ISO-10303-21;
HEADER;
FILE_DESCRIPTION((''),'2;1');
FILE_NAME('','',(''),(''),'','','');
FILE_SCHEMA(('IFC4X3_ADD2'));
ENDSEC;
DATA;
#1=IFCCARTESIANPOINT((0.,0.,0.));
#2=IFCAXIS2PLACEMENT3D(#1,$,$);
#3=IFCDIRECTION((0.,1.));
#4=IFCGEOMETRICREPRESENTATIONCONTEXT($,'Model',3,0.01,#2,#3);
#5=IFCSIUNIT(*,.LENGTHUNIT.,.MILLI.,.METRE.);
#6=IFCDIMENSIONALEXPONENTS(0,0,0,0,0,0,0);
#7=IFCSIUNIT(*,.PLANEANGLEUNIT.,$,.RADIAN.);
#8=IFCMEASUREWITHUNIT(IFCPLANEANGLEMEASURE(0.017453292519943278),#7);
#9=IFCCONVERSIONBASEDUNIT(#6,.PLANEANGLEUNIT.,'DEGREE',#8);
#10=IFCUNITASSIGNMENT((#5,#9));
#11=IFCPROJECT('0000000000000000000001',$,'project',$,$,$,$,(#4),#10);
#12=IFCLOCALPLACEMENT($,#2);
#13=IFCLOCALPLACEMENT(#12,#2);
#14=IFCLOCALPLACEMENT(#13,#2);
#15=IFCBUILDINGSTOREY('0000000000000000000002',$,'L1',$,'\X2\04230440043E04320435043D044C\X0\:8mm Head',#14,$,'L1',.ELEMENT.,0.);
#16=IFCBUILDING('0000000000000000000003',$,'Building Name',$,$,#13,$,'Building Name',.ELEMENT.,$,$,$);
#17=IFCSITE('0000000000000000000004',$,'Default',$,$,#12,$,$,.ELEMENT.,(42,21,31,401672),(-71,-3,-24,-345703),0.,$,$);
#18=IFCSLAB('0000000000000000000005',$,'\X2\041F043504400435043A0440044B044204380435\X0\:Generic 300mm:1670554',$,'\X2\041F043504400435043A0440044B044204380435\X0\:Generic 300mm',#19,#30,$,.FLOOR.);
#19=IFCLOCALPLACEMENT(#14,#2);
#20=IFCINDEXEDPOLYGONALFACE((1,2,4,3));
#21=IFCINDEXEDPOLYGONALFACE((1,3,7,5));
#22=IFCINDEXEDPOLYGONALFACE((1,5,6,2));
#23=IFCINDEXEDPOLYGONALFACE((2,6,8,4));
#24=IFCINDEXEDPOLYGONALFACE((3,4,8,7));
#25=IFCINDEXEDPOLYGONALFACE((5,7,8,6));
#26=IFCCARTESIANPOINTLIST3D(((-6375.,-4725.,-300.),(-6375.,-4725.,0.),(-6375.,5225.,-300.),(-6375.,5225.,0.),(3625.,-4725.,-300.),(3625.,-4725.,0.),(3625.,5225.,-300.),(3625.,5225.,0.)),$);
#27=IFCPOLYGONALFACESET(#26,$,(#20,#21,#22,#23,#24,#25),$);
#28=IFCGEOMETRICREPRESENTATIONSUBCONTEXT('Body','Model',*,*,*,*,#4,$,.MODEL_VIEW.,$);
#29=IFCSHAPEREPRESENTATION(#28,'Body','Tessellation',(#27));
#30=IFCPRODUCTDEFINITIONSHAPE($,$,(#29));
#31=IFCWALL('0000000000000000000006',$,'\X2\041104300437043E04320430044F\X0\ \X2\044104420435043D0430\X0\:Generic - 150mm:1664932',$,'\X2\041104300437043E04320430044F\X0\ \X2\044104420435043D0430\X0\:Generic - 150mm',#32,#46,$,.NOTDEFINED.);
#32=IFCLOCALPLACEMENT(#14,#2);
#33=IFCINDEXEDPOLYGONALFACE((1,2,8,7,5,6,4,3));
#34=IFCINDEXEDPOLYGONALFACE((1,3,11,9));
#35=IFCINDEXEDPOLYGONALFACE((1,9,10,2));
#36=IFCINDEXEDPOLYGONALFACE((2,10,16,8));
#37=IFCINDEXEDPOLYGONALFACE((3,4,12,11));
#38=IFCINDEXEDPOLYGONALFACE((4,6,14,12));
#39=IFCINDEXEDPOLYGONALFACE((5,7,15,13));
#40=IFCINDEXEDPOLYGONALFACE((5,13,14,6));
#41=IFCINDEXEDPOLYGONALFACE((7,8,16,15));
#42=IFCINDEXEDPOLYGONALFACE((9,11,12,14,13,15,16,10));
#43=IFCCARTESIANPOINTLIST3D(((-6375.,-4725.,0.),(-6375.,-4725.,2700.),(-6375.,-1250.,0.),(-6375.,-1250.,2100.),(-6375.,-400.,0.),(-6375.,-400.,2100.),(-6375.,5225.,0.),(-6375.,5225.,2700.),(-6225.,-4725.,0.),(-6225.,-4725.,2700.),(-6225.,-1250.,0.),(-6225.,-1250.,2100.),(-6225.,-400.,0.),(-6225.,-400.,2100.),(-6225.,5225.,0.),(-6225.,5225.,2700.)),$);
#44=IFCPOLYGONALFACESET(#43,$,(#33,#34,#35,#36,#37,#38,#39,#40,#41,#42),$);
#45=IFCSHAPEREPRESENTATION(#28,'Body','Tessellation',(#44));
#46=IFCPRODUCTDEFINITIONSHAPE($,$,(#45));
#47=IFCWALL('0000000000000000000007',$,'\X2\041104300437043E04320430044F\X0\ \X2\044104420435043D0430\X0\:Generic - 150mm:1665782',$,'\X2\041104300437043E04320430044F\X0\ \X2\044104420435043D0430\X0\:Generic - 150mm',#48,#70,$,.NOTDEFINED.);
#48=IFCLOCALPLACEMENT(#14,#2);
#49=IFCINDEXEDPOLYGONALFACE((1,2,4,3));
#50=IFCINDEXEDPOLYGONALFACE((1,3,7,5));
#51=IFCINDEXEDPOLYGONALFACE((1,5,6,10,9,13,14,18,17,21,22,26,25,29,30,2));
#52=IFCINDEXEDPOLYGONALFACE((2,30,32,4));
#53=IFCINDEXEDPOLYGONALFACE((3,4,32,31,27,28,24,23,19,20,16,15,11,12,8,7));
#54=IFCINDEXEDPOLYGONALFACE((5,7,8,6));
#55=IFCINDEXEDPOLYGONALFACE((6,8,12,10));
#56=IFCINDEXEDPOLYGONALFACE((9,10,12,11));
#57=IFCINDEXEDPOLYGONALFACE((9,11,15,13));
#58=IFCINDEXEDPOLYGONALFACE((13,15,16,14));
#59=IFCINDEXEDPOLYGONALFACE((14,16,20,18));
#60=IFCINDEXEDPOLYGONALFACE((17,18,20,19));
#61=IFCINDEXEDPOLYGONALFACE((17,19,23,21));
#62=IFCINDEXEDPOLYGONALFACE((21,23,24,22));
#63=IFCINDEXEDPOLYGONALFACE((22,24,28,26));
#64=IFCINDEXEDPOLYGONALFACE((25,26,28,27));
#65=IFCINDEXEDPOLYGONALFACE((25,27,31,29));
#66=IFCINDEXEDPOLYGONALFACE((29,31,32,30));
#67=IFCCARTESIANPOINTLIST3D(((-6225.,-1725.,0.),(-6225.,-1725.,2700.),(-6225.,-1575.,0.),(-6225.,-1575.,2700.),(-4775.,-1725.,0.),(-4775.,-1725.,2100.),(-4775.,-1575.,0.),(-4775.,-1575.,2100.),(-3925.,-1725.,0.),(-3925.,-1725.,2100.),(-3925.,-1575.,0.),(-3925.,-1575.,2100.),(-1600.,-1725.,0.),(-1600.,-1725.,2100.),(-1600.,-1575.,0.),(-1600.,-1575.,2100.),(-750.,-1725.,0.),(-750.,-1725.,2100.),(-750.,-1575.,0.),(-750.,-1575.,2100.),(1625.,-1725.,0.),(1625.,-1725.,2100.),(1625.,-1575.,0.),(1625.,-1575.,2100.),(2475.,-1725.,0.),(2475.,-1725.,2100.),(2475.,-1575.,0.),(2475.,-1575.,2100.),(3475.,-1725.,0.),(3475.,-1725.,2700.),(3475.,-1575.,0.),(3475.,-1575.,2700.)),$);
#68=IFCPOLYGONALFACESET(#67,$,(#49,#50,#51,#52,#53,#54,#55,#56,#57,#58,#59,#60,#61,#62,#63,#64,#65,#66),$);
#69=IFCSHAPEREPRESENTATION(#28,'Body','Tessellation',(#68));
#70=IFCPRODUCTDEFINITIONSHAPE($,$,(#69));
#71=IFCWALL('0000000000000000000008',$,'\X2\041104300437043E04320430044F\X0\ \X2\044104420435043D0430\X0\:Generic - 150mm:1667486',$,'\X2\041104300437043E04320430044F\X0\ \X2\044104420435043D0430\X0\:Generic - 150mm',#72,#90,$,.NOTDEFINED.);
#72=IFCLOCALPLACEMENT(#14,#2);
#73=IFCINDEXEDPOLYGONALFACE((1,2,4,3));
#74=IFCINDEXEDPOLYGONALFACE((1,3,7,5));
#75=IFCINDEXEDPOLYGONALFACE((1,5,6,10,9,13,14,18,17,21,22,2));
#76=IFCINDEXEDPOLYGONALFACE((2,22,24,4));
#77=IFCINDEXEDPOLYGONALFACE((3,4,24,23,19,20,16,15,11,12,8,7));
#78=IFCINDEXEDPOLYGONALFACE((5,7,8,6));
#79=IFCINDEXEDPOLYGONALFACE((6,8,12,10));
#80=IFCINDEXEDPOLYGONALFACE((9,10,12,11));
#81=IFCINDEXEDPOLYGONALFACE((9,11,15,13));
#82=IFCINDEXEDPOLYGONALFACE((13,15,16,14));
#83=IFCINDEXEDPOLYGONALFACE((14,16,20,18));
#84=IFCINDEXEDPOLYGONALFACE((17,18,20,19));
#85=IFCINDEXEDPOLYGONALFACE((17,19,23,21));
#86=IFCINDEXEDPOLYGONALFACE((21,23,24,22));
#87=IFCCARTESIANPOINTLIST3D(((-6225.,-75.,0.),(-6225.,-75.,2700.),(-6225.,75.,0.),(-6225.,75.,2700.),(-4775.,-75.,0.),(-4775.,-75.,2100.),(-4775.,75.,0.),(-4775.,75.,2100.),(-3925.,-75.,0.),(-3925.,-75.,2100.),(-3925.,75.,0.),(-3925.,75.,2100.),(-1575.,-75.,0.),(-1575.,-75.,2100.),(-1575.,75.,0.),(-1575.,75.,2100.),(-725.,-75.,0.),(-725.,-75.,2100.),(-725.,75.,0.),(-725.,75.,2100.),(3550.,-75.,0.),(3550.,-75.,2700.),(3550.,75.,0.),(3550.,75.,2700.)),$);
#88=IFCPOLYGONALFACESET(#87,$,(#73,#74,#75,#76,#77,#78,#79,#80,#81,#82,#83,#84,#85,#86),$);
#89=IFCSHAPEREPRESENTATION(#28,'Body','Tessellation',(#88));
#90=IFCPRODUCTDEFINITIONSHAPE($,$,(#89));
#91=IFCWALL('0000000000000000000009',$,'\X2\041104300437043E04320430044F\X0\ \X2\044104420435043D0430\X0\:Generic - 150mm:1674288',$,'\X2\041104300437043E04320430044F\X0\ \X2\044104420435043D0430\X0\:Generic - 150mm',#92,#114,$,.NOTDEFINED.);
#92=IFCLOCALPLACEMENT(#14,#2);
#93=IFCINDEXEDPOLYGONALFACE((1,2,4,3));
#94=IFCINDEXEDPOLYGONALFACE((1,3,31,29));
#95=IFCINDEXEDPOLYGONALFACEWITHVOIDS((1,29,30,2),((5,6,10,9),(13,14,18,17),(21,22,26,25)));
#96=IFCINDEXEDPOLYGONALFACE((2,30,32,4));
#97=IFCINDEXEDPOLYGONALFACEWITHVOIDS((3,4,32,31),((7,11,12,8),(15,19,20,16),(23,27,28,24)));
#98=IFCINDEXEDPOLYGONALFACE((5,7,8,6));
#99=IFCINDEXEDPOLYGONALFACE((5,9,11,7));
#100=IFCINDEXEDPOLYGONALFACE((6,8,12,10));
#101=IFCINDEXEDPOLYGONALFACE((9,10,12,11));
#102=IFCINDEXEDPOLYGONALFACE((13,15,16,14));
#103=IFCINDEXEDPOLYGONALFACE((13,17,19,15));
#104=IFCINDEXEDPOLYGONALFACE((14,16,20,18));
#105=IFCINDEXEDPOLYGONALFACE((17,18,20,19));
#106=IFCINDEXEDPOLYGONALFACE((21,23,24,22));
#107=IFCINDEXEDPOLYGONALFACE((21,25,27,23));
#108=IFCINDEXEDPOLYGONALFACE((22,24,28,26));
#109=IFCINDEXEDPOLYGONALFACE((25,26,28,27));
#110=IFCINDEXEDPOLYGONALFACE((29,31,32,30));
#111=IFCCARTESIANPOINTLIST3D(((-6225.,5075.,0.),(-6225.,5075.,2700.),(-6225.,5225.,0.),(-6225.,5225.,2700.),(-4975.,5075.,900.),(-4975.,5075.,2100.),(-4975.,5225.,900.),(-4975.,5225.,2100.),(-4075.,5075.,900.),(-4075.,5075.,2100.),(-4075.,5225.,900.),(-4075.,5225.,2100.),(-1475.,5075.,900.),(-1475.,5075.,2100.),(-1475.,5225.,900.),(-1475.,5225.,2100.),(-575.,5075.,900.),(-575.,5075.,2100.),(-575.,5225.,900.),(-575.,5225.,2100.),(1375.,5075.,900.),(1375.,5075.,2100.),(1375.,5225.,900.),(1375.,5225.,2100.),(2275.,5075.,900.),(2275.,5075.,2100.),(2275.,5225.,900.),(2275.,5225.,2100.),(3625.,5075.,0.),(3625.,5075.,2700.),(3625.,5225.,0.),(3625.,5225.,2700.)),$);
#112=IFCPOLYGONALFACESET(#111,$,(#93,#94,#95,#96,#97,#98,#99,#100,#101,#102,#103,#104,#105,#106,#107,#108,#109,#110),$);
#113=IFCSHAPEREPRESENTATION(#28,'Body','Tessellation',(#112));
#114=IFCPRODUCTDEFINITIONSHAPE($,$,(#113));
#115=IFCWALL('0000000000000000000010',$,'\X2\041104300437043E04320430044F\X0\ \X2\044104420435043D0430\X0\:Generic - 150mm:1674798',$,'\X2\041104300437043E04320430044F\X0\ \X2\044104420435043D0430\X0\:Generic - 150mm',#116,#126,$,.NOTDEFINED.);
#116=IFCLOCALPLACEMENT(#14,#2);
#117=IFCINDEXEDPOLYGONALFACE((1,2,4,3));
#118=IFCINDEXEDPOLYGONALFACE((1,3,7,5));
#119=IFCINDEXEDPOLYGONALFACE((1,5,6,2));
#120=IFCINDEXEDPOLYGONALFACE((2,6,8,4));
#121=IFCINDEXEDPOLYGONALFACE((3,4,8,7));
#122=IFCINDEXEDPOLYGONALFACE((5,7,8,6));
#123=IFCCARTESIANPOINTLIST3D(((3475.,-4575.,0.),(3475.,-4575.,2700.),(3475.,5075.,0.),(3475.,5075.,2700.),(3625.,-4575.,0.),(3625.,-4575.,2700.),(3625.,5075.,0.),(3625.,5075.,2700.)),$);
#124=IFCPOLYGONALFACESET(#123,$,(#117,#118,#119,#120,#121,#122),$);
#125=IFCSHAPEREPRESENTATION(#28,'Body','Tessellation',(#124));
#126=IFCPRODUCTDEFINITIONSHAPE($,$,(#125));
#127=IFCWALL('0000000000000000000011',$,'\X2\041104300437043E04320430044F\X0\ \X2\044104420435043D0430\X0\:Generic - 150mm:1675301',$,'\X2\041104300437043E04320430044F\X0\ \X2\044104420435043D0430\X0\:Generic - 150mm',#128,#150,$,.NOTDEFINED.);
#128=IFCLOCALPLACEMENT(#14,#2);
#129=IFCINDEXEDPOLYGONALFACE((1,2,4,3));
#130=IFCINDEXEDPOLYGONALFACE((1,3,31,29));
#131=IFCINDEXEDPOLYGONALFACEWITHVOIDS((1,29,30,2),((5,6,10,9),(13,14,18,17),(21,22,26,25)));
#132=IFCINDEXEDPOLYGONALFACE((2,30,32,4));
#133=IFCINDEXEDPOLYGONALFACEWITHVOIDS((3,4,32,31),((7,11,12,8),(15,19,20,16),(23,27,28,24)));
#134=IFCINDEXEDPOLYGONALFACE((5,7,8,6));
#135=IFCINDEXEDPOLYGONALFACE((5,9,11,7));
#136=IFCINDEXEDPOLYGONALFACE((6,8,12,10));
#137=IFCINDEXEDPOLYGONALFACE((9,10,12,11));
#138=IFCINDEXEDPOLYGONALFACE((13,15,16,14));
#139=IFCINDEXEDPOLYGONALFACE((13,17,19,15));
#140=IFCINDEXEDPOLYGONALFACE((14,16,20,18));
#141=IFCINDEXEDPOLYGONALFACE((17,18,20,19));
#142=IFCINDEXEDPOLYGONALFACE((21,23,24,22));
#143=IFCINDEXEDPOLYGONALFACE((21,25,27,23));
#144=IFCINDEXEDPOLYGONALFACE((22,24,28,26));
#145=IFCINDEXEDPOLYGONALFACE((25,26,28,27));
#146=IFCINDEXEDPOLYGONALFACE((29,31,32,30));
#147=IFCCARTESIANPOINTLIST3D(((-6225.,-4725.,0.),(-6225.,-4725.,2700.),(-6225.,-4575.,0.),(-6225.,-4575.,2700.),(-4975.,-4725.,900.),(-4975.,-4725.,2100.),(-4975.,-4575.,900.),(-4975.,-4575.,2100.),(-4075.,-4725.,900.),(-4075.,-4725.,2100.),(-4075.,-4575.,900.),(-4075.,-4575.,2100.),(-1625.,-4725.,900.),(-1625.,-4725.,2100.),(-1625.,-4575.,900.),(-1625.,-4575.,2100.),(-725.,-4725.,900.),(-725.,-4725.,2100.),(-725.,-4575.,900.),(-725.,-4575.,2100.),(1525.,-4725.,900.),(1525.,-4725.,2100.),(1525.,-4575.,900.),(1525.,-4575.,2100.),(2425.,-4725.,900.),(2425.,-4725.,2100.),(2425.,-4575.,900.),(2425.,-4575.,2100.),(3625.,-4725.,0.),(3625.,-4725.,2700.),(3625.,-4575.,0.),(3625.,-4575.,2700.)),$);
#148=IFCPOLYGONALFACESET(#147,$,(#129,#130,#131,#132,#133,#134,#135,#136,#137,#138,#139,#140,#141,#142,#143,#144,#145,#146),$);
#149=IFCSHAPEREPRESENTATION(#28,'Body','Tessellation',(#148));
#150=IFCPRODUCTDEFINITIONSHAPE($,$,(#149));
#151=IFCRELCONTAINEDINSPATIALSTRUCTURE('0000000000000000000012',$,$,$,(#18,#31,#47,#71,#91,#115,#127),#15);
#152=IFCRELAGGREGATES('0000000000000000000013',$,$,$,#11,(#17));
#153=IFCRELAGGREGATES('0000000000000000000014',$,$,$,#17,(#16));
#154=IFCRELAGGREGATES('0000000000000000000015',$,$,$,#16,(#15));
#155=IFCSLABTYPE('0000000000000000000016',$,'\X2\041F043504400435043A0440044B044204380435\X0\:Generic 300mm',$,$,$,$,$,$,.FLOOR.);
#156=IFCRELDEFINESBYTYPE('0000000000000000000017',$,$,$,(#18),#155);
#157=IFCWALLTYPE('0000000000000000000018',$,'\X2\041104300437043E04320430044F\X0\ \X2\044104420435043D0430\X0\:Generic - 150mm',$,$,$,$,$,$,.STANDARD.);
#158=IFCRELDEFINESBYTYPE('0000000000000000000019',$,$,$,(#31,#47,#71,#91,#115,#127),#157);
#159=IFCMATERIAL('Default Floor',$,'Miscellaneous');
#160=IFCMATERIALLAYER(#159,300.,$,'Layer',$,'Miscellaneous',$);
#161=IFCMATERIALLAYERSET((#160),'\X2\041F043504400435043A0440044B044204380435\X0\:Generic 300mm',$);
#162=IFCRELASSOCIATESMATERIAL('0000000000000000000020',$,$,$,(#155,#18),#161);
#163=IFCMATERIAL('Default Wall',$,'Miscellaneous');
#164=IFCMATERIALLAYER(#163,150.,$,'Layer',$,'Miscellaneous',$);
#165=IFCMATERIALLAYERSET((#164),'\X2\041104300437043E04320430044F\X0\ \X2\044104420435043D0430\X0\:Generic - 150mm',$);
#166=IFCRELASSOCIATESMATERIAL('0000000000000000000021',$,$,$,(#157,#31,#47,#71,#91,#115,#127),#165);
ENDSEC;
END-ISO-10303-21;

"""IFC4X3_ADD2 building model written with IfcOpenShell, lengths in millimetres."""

from ifc_helpers import new_model, entity, si_unit, converted_unit, direction, frame, frame_2d, origin, origin_2d_with_axis, place, context, subcontext, project, spatial, rectangle, extrude, material, layer, layer_set, layer_usage, type_object, element, save


model = new_model("IFC4X3_ADD2")

# Units and contexts
model_context = context("Model", 3, precision=0.01, world=origin(), true_north=direction((0.0, 1.0)))
body_context = subcontext(model_context, "Body", "Model", "MODEL_VIEW")
ifc_project = project(units=[si_unit("LENGTHUNIT", "METRE", prefix="MILLI"), converted_unit("PLANEANGLEUNIT", "DEGREE", entity("IfcPlaneAngleMeasure", 0.017453292519943278), si_unit("PLANEANGLEUNIT", "RADIAN"), dimensions=[0, 0, 0, 0, 0, 0, 0])], contexts=[model_context])

# Site, building, storey
site_placement = place(None, origin())
site = spatial("IfcSite", under=ifc_project, at=site_placement, Name="Default", CompositionType="ELEMENT", RefLatitude=(42, 21, 31, 401672), RefLongitude=(-71, -3, -24, -345703), RefElevation=0.0)
building_placement = place(site_placement, origin())
building = spatial("IfcBuilding", under=site, at=building_placement, Name="Building Name", LongName="Building Name", CompositionType="ELEMENT")
storey_placement = place(building_placement, origin())
storey = spatial("IfcBuildingStorey", under=building, at=storey_placement, Name="L1", ObjectType="Уровень:8mm Head", LongName="L1", CompositionType="ELEMENT", Elevation=0.0)

# Slab
ifc_material_1 = material(Name="Default Floor", Category="Miscellaneous")
ifc_layer_1 = layer(ifc_material_1, 300.0, Name="Layer", Category="Miscellaneous")
ifc_layer_set_1 = layer_set([ifc_layer_1], Name="Перекрытие:Generic 300mm")
ifc_layer_usage = layer_usage(ifc_layer_set_1, "AXIS3", "POSITIVE", 0.0)
slab_type = type_object("IfcSlabType", Name="Перекрытие:Generic 300mm", PredefinedType="FLOOR", material=ifc_layer_set_1)
slab_placement = place(storey_placement, origin())
element("IfcSlab", 1, at=slab_placement, inside=storey, type_object=slab_type, material=ifc_layer_usage, Name="Перекрытие:Generic 300mm:1670554", ObjectType="Перекрытие:Generic 300mm", PredefinedType="FLOOR", context=body_context, shape_type="SweptSolid", body=[
    extrude(rectangle(XDim=9950.0, YDim=10000.0, at=origin_2d_with_axis()), frame((-1375.0, 250.0, 0.0), z_axis=(0.0, 0.0, -1.0), x_axis=(0.0, 1.0, 0.0)), (0.0, 0.0, 1.0), 300.0),
])

# Wall, opening
ifc_material_2 = material(Name="Default Wall", Category="Miscellaneous")
ifc_layer_2 = layer(ifc_material_2, 150.0, Name="Layer", Category="Miscellaneous")
ifc_layer_set_2 = layer_set([ifc_layer_2], Name="Базовая стена:Generic - 150mm")
wall_type = type_object("IfcWallType", Name="Базовая стена:Generic - 150mm", PredefinedType="STANDARD", material=ifc_layer_set_2)
wall_1_placement = place(storey_placement, frame((-6300.0, 5225.0, 0.0), z_axis=(0.0, 0.0, 1.0), x_axis=(0.0, -1.0, 0.0)))
wall_1 = element("IfcWall", 2, at=wall_1_placement, inside=storey, type_object=wall_type, material=ifc_layer_set_2, Name="Базовая стена:Generic - 150mm:1664932", ObjectType="Базовая стена:Generic - 150mm", PredefinedType="NOTDEFINED", context=body_context, shape_type="SweptSolid", body=[
    extrude(rectangle(XDim=9950.0, YDim=150.0, at=frame_2d((4975.0, 0.0), x_axis=(-1.0, 0.0))), origin(), (0.0, 0.0, 1.0), 2700.0),
])
opening_1_placement = place(wall_1_placement, frame((6475.0, 75.0, 0.0)))
element("IfcOpeningElement", 3, at=opening_1_placement, cuts=wall_1, PredefinedType="OPENING", context=body_context, shape_type="SweptSolid", body=[
    extrude(rectangle(XDim=2100.0, YDim=850.0, at=frame_2d((1050.0, 425.0), x_axis=(1.0, 0.0))), frame((0.0, 0.0, 0.0), z_axis=(0.0, -1.0, 0.0), x_axis=(0.0, 0.0, 1.0)), (0.0, 0.0, 1.0), 150.0),
])

# Walls, openings
wall_2_placement = place(storey_placement, frame((3475.0, -1650.0, 0.0), z_axis=(0.0, 0.0, 1.0), x_axis=(-1.0, 0.0, 0.0)))
wall_2 = element("IfcWall", 4, at=wall_2_placement, inside=storey, type_object=wall_type, material=ifc_layer_set_2, Name="Базовая стена:Generic - 150mm:1665782", ObjectType="Базовая стена:Generic - 150mm", PredefinedType="NOTDEFINED", context=body_context, shape_type="SweptSolid", body=[
    extrude(rectangle(XDim=9700.0, YDim=150.0, at=frame_2d((4850.0, 0.0), x_axis=(1.0, 0.0))), origin(), (0.0, 0.0, 1.0), 2700.0),
])
opening_2_placement = place(wall_2_placement, frame((7400.0, -75.0, 0.0)))
element("IfcOpeningElement", 5, at=opening_2_placement, cuts=wall_2, PredefinedType="OPENING", context=body_context, shape_type="SweptSolid", body=[
    extrude(rectangle(XDim=2100.0, YDim=850.0, at=frame_2d((1050.0, 425.0), x_axis=(1.0, 0.0))), frame((0.0, 0.0, 0.0), z_axis=(0.0, 1.0, 0.0), x_axis=(0.0, 0.0, 1.0)), (0.0, 0.0, 1.0), 150.0),
])
opening_3_placement = place(wall_2_placement, frame((4225.0, -75.0, 0.0)))
element("IfcOpeningElement", 6, at=opening_3_placement, cuts=wall_2, PredefinedType="OPENING", context=body_context, shape_type="SweptSolid", body=[
    extrude(rectangle(XDim=2100.0, YDim=850.0, at=frame_2d((1050.0, 425.0), x_axis=(1.0, 0.0))), frame((0.0, 0.0, 0.0), z_axis=(0.0, 1.0, 0.0), x_axis=(0.0, 0.0, 1.0)), (0.0, 0.0, 1.0), 150.0),
])
opening_4_placement = place(wall_2_placement, frame((1000.0, -75.0, 0.0)))
element("IfcOpeningElement", 7, at=opening_4_placement, cuts=wall_2, PredefinedType="OPENING", context=body_context, shape_type="SweptSolid", body=[
    extrude(rectangle(XDim=2100.0, YDim=850.0, at=frame_2d((1050.0, 425.0), x_axis=(1.0, 0.0))), frame((0.0, 0.0, 0.0), z_axis=(0.0, 1.0, 0.0), x_axis=(0.0, 0.0, 1.0)), (0.0, 0.0, 1.0), 150.0),
])
wall_3_placement = place(storey_placement, frame((3550.0, 0.0, 0.0), z_axis=(0.0, 0.0, 1.0), x_axis=(-1.0, 0.0, 0.0)))
wall_3 = element("IfcWall", 8, at=wall_3_placement, inside=storey, type_object=wall_type, material=ifc_layer_set_2, Name="Базовая стена:Generic - 150mm:1667486", ObjectType="Базовая стена:Generic - 150mm", PredefinedType="NOTDEFINED", context=body_context, shape_type="SweptSolid", body=[
    extrude(rectangle(XDim=9775.0, YDim=150.0, at=frame_2d((4887.5, 0.0), x_axis=(1.0, 0.0))), origin(), (0.0, 0.0, 1.0), 2700.0),
])
opening_5_placement = place(wall_3_placement, frame((8325.0, 75.0, 0.0)))
element("IfcOpeningElement", 9, at=opening_5_placement, cuts=wall_3, PredefinedType="OPENING", context=body_context, shape_type="SweptSolid", body=[
    extrude(rectangle(XDim=2100.0, YDim=850.0, at=frame_2d((1050.0, 425.0), x_axis=(1.0, 0.0))), frame((0.0, 0.0, 0.0), z_axis=(0.0, -1.0, 0.0), x_axis=(0.0, 0.0, 1.0)), (0.0, 0.0, 1.0), 150.0),
])
opening_6_placement = place(wall_3_placement, frame((5125.0, 75.0, 0.0)))
element("IfcOpeningElement", 10, at=opening_6_placement, cuts=wall_3, PredefinedType="OPENING", context=body_context, shape_type="SweptSolid", body=[
    extrude(rectangle(XDim=2100.0, YDim=850.0, at=frame_2d((1050.0, 425.0), x_axis=(1.0, 0.0))), frame((0.0, 0.0, 0.0), z_axis=(0.0, -1.0, 0.0), x_axis=(0.0, 0.0, 1.0)), (0.0, 0.0, 1.0), 150.0),
])
wall_4_placement = place(storey_placement, frame((-6225.0, 5150.0, 0.0)))
wall_4 = element("IfcWall", 11, at=wall_4_placement, inside=storey, type_object=wall_type, material=ifc_layer_set_2, Name="Базовая стена:Generic - 150mm:1674288", ObjectType="Базовая стена:Generic - 150mm", PredefinedType="NOTDEFINED", context=body_context, shape_type="SweptSolid", body=[
    extrude(rectangle(XDim=9850.0, YDim=150.0, at=frame_2d((4925.0, 0.0), x_axis=(-1.0, 0.0))), origin(), (0.0, 0.0, 1.0), 2700.0),
])
opening_7_placement = place(wall_4_placement, frame((1250.0, -75.0, 900.0)))
element("IfcOpeningElement", 12, at=opening_7_placement, cuts=wall_4, PredefinedType="OPENING", context=body_context, shape_type="SweptSolid", body=[
    extrude(rectangle(XDim=1200.0, YDim=900.0, at=frame_2d((600.0, 450.0), x_axis=(-1.0, 0.0))), frame((0.0, 0.0, 0.0), z_axis=(0.0, 1.0, 0.0), x_axis=(0.0, 0.0, 1.0)), (0.0, 0.0, 1.0), 150.0),
])
opening_8_placement = place(wall_4_placement, frame((4750.0, -75.0, 900.0)))
element("IfcOpeningElement", 13, at=opening_8_placement, cuts=wall_4, PredefinedType="OPENING", context=body_context, shape_type="SweptSolid", body=[
    extrude(rectangle(XDim=1200.0, YDim=900.0, at=frame_2d((600.0, 450.0), x_axis=(-1.0, 0.0))), frame((0.0, 0.0, 0.0), z_axis=(0.0, 1.0, 0.0), x_axis=(0.0, 0.0, 1.0)), (0.0, 0.0, 1.0), 150.0),
])
opening_9_placement = place(wall_4_placement, frame((7600.0, -75.0, 900.0)))
element("IfcOpeningElement", 14, at=opening_9_placement, cuts=wall_4, PredefinedType="OPENING", context=body_context, shape_type="SweptSolid", body=[
    extrude(rectangle(XDim=1200.0, YDim=900.0, at=frame_2d((600.0, 450.0), x_axis=(-1.0, 0.0))), frame((0.0, 0.0, 0.0), z_axis=(0.0, 1.0, 0.0), x_axis=(0.0, 0.0, 1.0)), (0.0, 0.0, 1.0), 150.0),
])

# Wall
wall_5_placement = place(storey_placement, frame((3550.0, -4575.0, 0.0), z_axis=(0.0, 0.0, 1.0), x_axis=(0.0, 1.0, 0.0)))
element("IfcWall", 15, at=wall_5_placement, inside=storey, type_object=wall_type, material=ifc_layer_set_2, Name="Базовая стена:Generic - 150mm:1674798", ObjectType="Базовая стена:Generic - 150mm", PredefinedType="NOTDEFINED", context=body_context, shape_type="SweptSolid", body=[
    extrude(rectangle(XDim=9650.0, YDim=150.0, at=frame_2d((4825.0, 0.0), x_axis=(-1.0, 0.0))), origin(), (0.0, 0.0, 1.0), 2700.0),
])

# Wall, openings
wall_6_placement = place(storey_placement, frame((-6225.0, -4650.0, 0.0)))
wall_6 = element("IfcWall", 16, at=wall_6_placement, inside=storey, type_object=wall_type, material=ifc_layer_set_2, Name="Базовая стена:Generic - 150mm:1675301", ObjectType="Базовая стена:Generic - 150mm", PredefinedType="NOTDEFINED", context=body_context, shape_type="SweptSolid", body=[
    extrude(rectangle(XDim=9850.0, YDim=150.0, at=frame_2d((4925.0, 0.0), x_axis=(-1.0, 0.0))), origin(), (0.0, 0.0, 1.0), 2700.0),
])
opening_10_placement = place(wall_6_placement, frame((8650.0, 75.0, 900.0)))
element("IfcOpeningElement", 17, at=opening_10_placement, cuts=wall_6, PredefinedType="OPENING", context=body_context, shape_type="SweptSolid", body=[
    extrude(rectangle(XDim=1200.0, YDim=900.0, at=frame_2d((600.0, 450.0), x_axis=(-1.0, 0.0))), frame((0.0, 0.0, 0.0), z_axis=(0.0, -1.0, 0.0), x_axis=(0.0, 0.0, 1.0)), (0.0, 0.0, 1.0), 150.0),
])
opening_11_placement = place(wall_6_placement, frame((5500.0, 75.0, 900.0)))
element("IfcOpeningElement", 18, at=opening_11_placement, cuts=wall_6, PredefinedType="OPENING", context=body_context, shape_type="SweptSolid", body=[
    extrude(rectangle(XDim=1200.0, YDim=900.0, at=frame_2d((600.0, 450.0), x_axis=(-1.0, 0.0))), frame((0.0, 0.0, 0.0), z_axis=(0.0, -1.0, 0.0), x_axis=(0.0, 0.0, 1.0)), (0.0, 0.0, 1.0), 150.0),
])
opening_12_placement = place(wall_6_placement, frame((2150.0, 75.0, 900.0)))
element("IfcOpeningElement", 19, at=opening_12_placement, cuts=wall_6, PredefinedType="OPENING", context=body_context, shape_type="SweptSolid", body=[
    extrude(rectangle(XDim=1200.0, YDim=900.0, at=frame_2d((600.0, 450.0), x_axis=(-1.0, 0.0))), frame((0.0, 0.0, 0.0), z_axis=(0.0, -1.0, 0.0), x_axis=(0.0, 0.0, 1.0)), (0.0, 0.0, 1.0), 150.0),
])

save(model, "model.ifc")
